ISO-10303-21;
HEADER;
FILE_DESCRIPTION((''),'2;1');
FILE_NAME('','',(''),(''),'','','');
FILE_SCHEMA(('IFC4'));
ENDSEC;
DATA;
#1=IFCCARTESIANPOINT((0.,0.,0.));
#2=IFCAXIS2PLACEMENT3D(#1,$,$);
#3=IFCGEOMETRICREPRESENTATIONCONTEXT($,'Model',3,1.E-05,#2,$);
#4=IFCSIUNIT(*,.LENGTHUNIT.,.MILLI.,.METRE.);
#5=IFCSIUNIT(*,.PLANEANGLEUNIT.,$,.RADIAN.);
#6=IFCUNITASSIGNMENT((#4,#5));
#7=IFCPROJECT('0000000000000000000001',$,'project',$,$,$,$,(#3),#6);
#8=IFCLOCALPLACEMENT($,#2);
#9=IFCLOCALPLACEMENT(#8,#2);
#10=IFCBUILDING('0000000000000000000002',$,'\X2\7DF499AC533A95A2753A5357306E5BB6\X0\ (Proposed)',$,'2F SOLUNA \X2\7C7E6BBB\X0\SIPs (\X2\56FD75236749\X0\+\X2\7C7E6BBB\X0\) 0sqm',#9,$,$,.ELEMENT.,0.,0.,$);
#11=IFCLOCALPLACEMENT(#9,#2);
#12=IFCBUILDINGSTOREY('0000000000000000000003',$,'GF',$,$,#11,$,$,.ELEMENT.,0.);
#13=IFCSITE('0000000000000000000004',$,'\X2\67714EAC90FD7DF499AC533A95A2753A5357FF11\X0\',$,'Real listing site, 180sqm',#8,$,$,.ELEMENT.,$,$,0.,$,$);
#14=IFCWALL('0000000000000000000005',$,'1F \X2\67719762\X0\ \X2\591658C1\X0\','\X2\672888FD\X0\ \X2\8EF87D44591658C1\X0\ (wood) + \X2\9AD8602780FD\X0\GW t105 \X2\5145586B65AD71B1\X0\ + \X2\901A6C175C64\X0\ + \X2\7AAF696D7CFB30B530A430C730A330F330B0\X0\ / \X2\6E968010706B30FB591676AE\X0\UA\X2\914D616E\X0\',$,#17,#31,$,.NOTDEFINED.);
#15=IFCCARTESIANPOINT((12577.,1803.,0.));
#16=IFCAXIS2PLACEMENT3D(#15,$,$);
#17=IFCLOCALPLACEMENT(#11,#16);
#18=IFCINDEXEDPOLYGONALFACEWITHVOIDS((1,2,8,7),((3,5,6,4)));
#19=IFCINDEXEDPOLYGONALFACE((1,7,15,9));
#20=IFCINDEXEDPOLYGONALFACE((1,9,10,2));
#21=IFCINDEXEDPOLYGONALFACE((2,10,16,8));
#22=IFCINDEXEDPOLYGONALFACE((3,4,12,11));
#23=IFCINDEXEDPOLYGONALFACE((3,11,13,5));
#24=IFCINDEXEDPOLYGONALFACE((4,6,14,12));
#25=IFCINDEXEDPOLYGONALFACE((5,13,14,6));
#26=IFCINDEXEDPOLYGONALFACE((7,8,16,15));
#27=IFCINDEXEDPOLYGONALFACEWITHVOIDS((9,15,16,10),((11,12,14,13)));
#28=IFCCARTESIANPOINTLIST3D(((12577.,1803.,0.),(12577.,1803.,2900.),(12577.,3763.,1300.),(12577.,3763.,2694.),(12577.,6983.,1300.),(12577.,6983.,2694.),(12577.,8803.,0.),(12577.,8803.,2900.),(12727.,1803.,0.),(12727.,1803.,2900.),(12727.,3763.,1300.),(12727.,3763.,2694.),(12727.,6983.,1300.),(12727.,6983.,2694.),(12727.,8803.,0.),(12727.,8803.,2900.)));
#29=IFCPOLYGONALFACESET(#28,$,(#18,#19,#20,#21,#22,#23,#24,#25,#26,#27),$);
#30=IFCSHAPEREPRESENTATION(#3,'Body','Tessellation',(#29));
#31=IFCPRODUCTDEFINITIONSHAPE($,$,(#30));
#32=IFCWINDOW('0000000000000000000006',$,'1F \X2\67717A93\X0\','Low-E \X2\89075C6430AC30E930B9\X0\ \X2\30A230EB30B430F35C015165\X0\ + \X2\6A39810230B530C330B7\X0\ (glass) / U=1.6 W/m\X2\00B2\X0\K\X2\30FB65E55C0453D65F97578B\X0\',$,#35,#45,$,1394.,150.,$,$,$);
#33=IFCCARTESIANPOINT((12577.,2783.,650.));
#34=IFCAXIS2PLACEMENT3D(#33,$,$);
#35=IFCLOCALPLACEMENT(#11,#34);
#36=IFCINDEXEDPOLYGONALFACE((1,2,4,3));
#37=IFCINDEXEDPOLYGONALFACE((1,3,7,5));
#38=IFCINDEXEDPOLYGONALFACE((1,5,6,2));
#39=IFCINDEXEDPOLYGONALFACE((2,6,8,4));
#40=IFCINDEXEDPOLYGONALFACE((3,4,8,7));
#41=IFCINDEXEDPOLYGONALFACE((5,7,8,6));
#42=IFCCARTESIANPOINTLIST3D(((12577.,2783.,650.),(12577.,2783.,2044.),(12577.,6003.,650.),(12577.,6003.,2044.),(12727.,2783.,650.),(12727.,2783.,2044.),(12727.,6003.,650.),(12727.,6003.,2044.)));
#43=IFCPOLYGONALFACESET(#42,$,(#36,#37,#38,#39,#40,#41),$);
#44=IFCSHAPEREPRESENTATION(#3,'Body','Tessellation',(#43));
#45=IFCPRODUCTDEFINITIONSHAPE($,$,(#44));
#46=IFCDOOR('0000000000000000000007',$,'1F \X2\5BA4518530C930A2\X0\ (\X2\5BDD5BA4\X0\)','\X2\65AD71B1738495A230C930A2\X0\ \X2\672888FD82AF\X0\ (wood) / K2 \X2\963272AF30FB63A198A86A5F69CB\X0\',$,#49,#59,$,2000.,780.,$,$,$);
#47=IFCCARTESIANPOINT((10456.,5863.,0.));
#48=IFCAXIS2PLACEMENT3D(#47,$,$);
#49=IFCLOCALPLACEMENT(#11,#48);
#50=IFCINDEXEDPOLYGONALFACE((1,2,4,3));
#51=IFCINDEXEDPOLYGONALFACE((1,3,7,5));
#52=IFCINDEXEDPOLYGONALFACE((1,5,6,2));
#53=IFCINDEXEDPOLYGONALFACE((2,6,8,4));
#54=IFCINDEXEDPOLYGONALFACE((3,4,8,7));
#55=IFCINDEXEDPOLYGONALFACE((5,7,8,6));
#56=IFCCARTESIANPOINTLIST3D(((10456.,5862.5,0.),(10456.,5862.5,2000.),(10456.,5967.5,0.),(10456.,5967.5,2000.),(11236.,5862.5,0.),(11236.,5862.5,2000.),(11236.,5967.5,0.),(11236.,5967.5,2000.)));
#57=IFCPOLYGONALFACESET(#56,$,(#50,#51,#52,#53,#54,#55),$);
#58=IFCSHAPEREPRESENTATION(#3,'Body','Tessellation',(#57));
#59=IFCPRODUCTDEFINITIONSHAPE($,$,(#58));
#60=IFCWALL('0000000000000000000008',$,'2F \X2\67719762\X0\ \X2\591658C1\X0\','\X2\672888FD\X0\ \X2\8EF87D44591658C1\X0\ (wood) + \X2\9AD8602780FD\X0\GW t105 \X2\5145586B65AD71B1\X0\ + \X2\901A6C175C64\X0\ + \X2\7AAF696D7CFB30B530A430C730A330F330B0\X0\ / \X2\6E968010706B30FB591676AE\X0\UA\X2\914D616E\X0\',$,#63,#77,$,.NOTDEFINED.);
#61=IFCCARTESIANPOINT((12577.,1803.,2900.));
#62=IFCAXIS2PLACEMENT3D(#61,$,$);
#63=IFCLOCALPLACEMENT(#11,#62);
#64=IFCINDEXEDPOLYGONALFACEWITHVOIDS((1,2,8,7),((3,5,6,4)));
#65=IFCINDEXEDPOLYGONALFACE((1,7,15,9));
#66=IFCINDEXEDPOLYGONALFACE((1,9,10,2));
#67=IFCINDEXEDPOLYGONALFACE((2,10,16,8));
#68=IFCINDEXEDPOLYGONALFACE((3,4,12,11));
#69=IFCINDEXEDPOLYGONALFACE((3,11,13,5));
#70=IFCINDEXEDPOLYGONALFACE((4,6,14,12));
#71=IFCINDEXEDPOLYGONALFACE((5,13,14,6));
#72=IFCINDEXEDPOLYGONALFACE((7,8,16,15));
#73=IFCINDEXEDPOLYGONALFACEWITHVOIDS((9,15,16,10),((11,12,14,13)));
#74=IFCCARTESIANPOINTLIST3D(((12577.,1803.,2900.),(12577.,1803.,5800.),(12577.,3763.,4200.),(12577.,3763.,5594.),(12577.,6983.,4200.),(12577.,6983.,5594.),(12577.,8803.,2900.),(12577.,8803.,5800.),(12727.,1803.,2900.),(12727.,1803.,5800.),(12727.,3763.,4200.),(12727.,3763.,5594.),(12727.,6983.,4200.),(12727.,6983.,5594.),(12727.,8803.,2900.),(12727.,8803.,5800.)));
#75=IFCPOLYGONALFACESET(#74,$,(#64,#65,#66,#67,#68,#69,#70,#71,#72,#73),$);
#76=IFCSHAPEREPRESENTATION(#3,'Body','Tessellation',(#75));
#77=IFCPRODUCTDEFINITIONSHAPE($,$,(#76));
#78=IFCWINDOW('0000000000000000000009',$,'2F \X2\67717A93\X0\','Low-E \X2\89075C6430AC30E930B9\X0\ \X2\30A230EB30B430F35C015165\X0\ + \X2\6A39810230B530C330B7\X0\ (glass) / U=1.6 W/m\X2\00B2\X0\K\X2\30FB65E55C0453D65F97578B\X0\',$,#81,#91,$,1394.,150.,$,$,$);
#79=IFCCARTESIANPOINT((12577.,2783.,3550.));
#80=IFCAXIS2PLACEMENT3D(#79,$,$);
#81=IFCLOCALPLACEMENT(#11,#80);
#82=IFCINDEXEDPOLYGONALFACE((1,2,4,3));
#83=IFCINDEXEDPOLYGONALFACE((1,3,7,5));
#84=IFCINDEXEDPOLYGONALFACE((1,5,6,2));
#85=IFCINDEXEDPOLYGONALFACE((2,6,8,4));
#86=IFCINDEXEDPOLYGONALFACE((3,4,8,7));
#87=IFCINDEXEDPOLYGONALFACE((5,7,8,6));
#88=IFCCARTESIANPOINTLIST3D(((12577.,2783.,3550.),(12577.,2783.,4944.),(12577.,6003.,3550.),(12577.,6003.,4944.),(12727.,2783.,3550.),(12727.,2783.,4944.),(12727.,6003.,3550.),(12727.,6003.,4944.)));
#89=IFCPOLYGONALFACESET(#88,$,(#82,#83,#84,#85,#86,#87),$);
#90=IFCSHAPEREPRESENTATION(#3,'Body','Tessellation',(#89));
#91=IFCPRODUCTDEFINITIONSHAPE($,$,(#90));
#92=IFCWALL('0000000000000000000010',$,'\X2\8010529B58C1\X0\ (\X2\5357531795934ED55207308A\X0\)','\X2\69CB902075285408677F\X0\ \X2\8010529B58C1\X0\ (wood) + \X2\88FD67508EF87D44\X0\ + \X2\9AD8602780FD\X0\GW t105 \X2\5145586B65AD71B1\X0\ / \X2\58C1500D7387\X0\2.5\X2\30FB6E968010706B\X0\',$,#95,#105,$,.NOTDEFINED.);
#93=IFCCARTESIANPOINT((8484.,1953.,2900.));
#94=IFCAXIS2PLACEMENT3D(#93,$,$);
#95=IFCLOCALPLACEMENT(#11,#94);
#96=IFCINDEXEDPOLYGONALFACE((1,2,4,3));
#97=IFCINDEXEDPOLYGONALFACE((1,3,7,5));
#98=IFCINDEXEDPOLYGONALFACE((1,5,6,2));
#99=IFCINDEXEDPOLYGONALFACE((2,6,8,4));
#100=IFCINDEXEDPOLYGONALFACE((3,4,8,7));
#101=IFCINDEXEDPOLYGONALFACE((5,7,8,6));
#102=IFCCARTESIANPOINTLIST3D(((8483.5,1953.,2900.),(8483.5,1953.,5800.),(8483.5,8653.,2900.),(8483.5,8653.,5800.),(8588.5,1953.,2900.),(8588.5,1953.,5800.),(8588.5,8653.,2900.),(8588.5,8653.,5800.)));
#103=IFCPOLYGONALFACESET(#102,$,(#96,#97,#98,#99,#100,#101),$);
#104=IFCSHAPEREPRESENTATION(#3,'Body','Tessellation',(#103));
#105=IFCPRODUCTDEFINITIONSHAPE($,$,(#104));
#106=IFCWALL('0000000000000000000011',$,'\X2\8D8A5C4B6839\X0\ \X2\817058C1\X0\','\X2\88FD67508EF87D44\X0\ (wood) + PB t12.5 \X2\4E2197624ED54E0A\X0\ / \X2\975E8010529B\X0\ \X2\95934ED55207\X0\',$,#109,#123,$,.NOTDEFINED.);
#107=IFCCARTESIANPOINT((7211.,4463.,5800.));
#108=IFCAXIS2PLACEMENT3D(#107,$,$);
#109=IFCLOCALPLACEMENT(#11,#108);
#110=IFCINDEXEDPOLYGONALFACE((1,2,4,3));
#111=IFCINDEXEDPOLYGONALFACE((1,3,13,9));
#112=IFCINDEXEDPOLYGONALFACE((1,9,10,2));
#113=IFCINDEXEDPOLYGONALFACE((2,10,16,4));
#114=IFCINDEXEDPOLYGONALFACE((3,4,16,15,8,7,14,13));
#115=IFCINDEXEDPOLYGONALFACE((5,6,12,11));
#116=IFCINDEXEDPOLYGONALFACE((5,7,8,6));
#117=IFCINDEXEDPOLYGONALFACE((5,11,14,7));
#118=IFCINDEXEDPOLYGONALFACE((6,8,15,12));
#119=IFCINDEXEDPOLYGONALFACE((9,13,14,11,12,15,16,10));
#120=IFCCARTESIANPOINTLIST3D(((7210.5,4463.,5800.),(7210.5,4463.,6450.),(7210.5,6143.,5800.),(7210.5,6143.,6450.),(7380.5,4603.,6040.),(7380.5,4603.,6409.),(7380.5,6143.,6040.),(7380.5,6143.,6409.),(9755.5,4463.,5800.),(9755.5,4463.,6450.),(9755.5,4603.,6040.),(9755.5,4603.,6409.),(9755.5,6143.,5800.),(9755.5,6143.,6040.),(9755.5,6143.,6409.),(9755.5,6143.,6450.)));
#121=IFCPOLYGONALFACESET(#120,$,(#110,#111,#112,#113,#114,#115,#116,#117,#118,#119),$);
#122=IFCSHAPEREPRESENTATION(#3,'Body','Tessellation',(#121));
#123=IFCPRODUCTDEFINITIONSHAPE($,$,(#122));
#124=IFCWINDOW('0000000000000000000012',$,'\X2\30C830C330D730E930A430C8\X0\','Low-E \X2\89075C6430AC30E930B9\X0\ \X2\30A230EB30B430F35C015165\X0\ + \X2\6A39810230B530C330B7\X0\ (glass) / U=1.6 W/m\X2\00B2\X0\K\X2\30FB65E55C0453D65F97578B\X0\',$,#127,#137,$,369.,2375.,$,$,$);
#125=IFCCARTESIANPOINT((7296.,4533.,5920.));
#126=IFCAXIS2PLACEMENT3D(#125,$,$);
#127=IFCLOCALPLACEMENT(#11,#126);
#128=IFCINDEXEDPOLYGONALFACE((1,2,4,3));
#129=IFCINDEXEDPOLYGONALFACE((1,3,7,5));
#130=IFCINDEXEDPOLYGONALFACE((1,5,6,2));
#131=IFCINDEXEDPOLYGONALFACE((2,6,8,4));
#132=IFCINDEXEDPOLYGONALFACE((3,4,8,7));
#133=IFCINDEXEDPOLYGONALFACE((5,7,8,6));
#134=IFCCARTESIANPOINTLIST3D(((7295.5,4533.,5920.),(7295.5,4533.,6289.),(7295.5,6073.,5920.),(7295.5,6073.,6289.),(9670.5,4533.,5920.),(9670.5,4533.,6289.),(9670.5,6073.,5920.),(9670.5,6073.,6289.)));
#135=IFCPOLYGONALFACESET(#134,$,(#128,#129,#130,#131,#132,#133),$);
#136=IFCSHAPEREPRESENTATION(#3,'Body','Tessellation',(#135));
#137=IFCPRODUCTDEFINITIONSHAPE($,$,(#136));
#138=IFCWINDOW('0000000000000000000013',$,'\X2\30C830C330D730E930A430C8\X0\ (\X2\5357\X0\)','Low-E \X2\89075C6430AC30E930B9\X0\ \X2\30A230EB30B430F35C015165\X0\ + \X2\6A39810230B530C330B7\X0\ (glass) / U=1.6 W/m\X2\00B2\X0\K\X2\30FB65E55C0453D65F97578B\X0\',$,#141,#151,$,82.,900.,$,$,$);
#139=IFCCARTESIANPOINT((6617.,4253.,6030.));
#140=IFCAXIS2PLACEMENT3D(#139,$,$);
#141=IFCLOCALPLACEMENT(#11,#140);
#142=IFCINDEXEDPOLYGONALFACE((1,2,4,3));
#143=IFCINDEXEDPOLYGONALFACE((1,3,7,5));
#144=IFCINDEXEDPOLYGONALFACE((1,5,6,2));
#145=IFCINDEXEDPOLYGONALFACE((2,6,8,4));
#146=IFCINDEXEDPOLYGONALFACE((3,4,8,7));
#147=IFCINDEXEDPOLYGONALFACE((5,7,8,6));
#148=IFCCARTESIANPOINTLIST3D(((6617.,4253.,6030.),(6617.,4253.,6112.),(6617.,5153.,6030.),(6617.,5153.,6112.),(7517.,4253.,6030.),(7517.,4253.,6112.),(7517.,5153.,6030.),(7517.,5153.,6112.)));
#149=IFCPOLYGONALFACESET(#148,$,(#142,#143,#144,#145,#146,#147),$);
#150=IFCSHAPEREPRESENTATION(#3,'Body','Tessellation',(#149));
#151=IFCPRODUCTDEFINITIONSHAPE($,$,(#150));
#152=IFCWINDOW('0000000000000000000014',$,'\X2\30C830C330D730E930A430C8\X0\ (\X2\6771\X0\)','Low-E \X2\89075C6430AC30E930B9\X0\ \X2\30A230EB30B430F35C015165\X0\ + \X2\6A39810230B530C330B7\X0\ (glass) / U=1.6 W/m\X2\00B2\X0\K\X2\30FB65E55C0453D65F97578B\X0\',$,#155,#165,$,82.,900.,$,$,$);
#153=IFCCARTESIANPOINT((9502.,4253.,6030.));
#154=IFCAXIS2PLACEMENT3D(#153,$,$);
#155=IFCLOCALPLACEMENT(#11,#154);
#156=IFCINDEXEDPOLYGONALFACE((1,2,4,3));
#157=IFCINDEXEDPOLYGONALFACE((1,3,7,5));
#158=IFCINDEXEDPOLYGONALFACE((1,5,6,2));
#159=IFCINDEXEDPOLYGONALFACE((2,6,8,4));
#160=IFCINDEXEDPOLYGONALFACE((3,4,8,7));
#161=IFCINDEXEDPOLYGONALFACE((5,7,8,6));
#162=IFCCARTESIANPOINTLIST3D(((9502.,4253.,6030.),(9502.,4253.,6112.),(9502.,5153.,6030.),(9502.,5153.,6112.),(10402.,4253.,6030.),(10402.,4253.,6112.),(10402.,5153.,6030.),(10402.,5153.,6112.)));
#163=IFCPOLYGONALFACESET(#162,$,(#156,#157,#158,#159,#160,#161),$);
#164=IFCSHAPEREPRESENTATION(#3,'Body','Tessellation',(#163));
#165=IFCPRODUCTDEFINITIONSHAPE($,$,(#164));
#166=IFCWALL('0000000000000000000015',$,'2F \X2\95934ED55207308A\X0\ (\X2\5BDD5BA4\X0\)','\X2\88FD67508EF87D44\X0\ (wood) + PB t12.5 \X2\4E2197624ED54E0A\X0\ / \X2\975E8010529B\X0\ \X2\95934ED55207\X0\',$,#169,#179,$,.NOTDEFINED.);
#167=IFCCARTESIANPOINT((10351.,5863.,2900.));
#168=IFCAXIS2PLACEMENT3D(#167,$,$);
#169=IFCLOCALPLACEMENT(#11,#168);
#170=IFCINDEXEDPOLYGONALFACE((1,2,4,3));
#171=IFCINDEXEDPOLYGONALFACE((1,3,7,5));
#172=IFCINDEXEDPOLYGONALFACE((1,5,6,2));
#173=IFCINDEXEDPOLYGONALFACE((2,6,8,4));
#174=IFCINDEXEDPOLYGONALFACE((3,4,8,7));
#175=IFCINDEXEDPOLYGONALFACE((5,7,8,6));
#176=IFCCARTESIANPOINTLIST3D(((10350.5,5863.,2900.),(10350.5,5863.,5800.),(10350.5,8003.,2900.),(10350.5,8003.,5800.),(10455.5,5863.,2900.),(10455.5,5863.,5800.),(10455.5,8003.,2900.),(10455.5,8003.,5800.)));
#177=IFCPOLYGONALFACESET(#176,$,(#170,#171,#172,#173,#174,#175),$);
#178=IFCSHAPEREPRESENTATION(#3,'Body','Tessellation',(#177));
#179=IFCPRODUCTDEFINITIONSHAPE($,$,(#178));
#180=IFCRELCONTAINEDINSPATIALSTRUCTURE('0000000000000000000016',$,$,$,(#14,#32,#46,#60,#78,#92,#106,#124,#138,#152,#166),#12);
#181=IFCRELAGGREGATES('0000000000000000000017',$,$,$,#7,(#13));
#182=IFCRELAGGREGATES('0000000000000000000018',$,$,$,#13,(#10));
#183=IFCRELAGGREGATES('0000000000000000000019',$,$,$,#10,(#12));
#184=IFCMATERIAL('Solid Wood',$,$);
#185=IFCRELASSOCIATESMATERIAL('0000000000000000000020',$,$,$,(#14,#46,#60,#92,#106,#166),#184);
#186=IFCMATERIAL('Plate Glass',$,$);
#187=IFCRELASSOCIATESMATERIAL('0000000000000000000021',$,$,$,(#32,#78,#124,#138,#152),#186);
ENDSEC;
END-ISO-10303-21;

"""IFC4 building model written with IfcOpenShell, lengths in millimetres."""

from ifc_helpers import new_model, si_unit, frame, frame_2d, origin, place, context, project, spatial, rectangle, extrude, material, element, fill, save


model = new_model("IFC4")

# Units and contexts
model_context = context("Model", 3, precision=1e-05, world=origin())
ifc_project = project(units=[si_unit("LENGTHUNIT", "METRE", prefix="MILLI"), si_unit("PLANEANGLEUNIT", "RADIAN")], contexts=[model_context])

# Site, building, storey
site_placement = place(None, origin())
site = spatial("IfcSite", under=ifc_project, at=site_placement, Name="東京都練馬区関町南１", ObjectType="Real listing site, 180sqm", CompositionType="ELEMENT", RefElevation=0.0)
building_placement = place(site_placement, origin())
building = spatial("IfcBuilding", under=site, at=building_placement, Name="練馬区関町南の家 (Proposed)", ObjectType="2F SOLUNA 籾殻SIPs (国産杉+籾殻) 0sqm", CompositionType="ELEMENT", ElevationOfRefHeight=0.0, ElevationOfTerrain=0.0)
storey_placement = place(building_placement, origin())
storey = spatial("IfcBuildingStorey", under=building, at=storey_placement, Name="GF", CompositionType="ELEMENT", Elevation=0.0)

# Wall, opening, window
ifc_material_1 = material(Name="Solid Wood")
wall_1_placement = place(storey_placement, frame((12577.0, 1803.0, 0.0)))
wall_1 = element("IfcWall", 1, at=wall_1_placement, inside=storey, material=ifc_material_1, Name="1F 東面 外壁", Description="木製 軸組外壁 (wood) + 高性能GW t105 充填断熱 + 通気層 + 窯業系サイディング / 準耐火・外皮UA配慮", PredefinedType="NOTDEFINED", context=model_context, shape_type="SweptSolid", body=[
    extrude(rectangle(XDim=150.0, YDim=7000.0, at=frame_2d((75.0, 3500.0))), frame((12577.0, 1803.0, 0.0)), (0.0, 0.0, 1.0), 2900.0),
])
opening_1_placement = place(storey_placement, frame((12577.0, 2783.0, 650.0)))
opening_1 = element("IfcOpeningElement", 2, at=opening_1_placement, cuts=wall_1, PredefinedType="NOTDEFINED", context=model_context, shape_type="SweptSolid", body=[
    extrude(rectangle(XDim=150.0, YDim=3220.0, at=frame_2d((75.0, 1610.0))), frame((12577.0, 2783.0, 650.0)), (0.0, 0.0, 1.0), 1394.0),
])
ifc_material_2 = material(Name="Plate Glass")
window_1_placement = place(storey_placement, frame((12577.0, 2783.0, 650.0)))
window_1 = element("IfcWindow", 3, at=window_1_placement, inside=storey, material=ifc_material_2, Name="1F 東窓", Description="Low-E 複層ガラス アルゴン封入 + 樹脂サッシ (glass) / U=1.6 W/m²K・日射取得型", OverallHeight=1394.0, OverallWidth=150.0, context=model_context, shape_type="SweptSolid", body=[
    extrude(rectangle(XDim=150.0, YDim=3220.0, at=frame_2d((75.0, 1610.0))), frame((12577.0, 2783.0, 650.0)), (0.0, 0.0, 1.0), 1394.0),
])
fill(opening_1, window_1)

# Door
door_1_placement = place(storey_placement, frame((10456.0, 5863.0, 0.0)))
element("IfcDoor", 4, at=door_1_placement, inside=storey, material=ifc_material_1, Name="1F 室内ドア (寝室)", Description="断熱玄関ドア 木製芯 (wood) / K2 防犯・採風機構", OverallHeight=2000.0, OverallWidth=780.0, context=model_context, shape_type="SweptSolid", body=[
    extrude(rectangle(XDim=780.0, YDim=105.0, at=frame_2d((390.0, 52.0))), frame((10456.0, 5863.0, 0.0)), (0.0, 0.0, 1.0), 2000.0),
])

# Wall, opening, window
wall_2_placement = place(storey_placement, frame((12577.0, 1803.0, 2900.0)))
wall_2 = element("IfcWall", 5, at=wall_2_placement, inside=storey, material=ifc_material_1, Name="2F 東面 外壁", Description="木製 軸組外壁 (wood) + 高性能GW t105 充填断熱 + 通気層 + 窯業系サイディング / 準耐火・外皮UA配慮", PredefinedType="NOTDEFINED", context=model_context, shape_type="SweptSolid", body=[
    extrude(rectangle(XDim=150.0, YDim=7000.0, at=frame_2d((75.0, 3500.0))), frame((12577.0, 1803.0, 2900.0)), (0.0, 0.0, 1.0), 2900.0),
])
opening_2_placement = place(storey_placement, frame((12577.0, 2783.0, 3550.0)))
opening_2 = element("IfcOpeningElement", 6, at=opening_2_placement, cuts=wall_2, PredefinedType="NOTDEFINED", context=model_context, shape_type="SweptSolid", body=[
    extrude(rectangle(XDim=150.0, YDim=3220.0, at=frame_2d((75.0, 1610.0))), frame((12577.0, 2783.0, 3550.0)), (0.0, 0.0, 1.0), 1394.0),
])
window_2_placement = place(storey_placement, frame((12577.0, 2783.0, 3550.0)))
window_2 = element("IfcWindow", 7, at=window_2_placement, inside=storey, material=ifc_material_2, Name="2F 東窓", Description="Low-E 複層ガラス アルゴン封入 + 樹脂サッシ (glass) / U=1.6 W/m²K・日射取得型", OverallHeight=1394.0, OverallWidth=150.0, context=model_context, shape_type="SweptSolid", body=[
    extrude(rectangle(XDim=150.0, YDim=3220.0, at=frame_2d((75.0, 1610.0))), frame((12577.0, 2783.0, 3550.0)), (0.0, 0.0, 1.0), 1394.0),
])
fill(opening_2, window_2)

# Wall
wall_3_placement = place(storey_placement, frame((8484.0, 1953.0, 2900.0)))
element("IfcWall", 8, at=wall_3_placement, inside=storey, material=ifc_material_1, Name="耐力壁 (南北間仕切り)", Description="構造用合板 耐力壁 (wood) + 製材軸組 + 高性能GW t105 充填断熱 / 壁倍率2.5・準耐火", PredefinedType="NOTDEFINED", context=model_context, shape_type="SweptSolid", body=[
    extrude(rectangle(XDim=105.0, YDim=6700.0, at=frame_2d((52.0, 3350.0))), frame((8484.0, 1953.0, 2900.0)), (0.0, 0.0, 1.0), 2900.0),
])

# Wall, openings, windows
wall_4_placement = place(storey_placement, frame((7211.0, 4463.0, 5800.0)))
wall_4 = element("IfcWall", 9, at=wall_4_placement, inside=storey, material=ifc_material_1, Name="越屋根 腰壁", Description="製材軸組 (wood) + PB t12.5 両面仕上 / 非耐力 間仕切", PredefinedType="NOTDEFINED", context=model_context, shape_type="SweptSolid", body=[
    extrude(rectangle(XDim=2545.0, YDim=1680.0, at=frame_2d((1272.0, 840.0))), frame((7211.0, 4463.0, 5800.0)), (0.0, 0.0, 1.0), 650.0),
])
opening_3_placement = place(storey_placement, frame((7296.0, 4533.0, 5920.0)))
opening_3 = element("IfcOpeningElement", 10, at=opening_3_placement, cuts=wall_4, PredefinedType="NOTDEFINED", context=model_context, shape_type="SweptSolid", body=[
    extrude(rectangle(XDim=2375.0, YDim=1540.0, at=frame_2d((1187.0, 770.0))), frame((7296.0, 4533.0, 5920.0)), (0.0, 0.0, 1.0), 369.0),
])
opening_4_placement = place(storey_placement, frame((6617.0, 4253.0, 6030.0)))
opening_4 = element("IfcOpeningElement", 11, at=opening_4_placement, cuts=wall_4, PredefinedType="NOTDEFINED", context=model_context, shape_type="SweptSolid", body=[
    extrude(rectangle(XDim=900.0, YDim=900.0, at=frame_2d((450.0, 450.0))), frame((6617.0, 4253.0, 6030.0)), (0.0, 0.0, 1.0), 82.0),
])
opening_5_placement = place(storey_placement, frame((9502.0, 4253.0, 6030.0)))
opening_5 = element("IfcOpeningElement", 12, at=opening_5_placement, cuts=wall_4, PredefinedType="NOTDEFINED", context=model_context, shape_type="SweptSolid", body=[
    extrude(rectangle(XDim=900.0, YDim=900.0, at=frame_2d((450.0, 450.0))), frame((9502.0, 4253.0, 6030.0)), (0.0, 0.0, 1.0), 82.0),
])
window_3_placement = place(storey_placement, frame((7296.0, 4533.0, 5920.0)))
window_3 = element("IfcWindow", 13, at=window_3_placement, inside=storey, material=ifc_material_2, Name="トップライト", Description="Low-E 複層ガラス アルゴン封入 + 樹脂サッシ (glass) / U=1.6 W/m²K・日射取得型", OverallHeight=369.0, OverallWidth=2375.0, context=model_context, shape_type="SweptSolid", body=[
    extrude(rectangle(XDim=2375.0, YDim=1540.0, at=frame_2d((1187.0, 770.0))), frame((7296.0, 4533.0, 5920.0)), (0.0, 0.0, 1.0), 369.0),
])
fill(opening_3, window_3)
window_4_placement = place(storey_placement, frame((6617.0, 4253.0, 6030.0)))
window_4 = element("IfcWindow", 14, at=window_4_placement, inside=storey, material=ifc_material_2, Name="トップライト (南)", Description="Low-E 複層ガラス アルゴン封入 + 樹脂サッシ (glass) / U=1.6 W/m²K・日射取得型", OverallHeight=82.0, OverallWidth=900.0, context=model_context, shape_type="SweptSolid", body=[
    extrude(rectangle(XDim=900.0, YDim=900.0, at=frame_2d((450.0, 450.0))), frame((6617.0, 4253.0, 6030.0)), (0.0, 0.0, 1.0), 82.0),
])
fill(opening_4, window_4)
window_5_placement = place(storey_placement, frame((9502.0, 4253.0, 6030.0)))
window_5 = element("IfcWindow", 15, at=window_5_placement, inside=storey, material=ifc_material_2, Name="トップライト (東)", Description="Low-E 複層ガラス アルゴン封入 + 樹脂サッシ (glass) / U=1.6 W/m²K・日射取得型", OverallHeight=82.0, OverallWidth=900.0, context=model_context, shape_type="SweptSolid", body=[
    extrude(rectangle(XDim=900.0, YDim=900.0, at=frame_2d((450.0, 450.0))), frame((9502.0, 4253.0, 6030.0)), (0.0, 0.0, 1.0), 82.0),
])
fill(opening_5, window_5)

# Wall
wall_5_placement = place(storey_placement, frame((10351.0, 5863.0, 2900.0)))
element("IfcWall", 16, at=wall_5_placement, inside=storey, material=ifc_material_1, Name="2F 間仕切り (寝室)", Description="製材軸組 (wood) + PB t12.5 両面仕上 / 非耐力 間仕切", PredefinedType="NOTDEFINED", context=model_context, shape_type="SweptSolid", body=[
    extrude(rectangle(XDim=105.0, YDim=2140.0, at=frame_2d((52.0, 1070.0))), frame((10351.0, 5863.0, 2900.0)), (0.0, 0.0, 1.0), 2900.0),
])

save(model, "model.ifc")
